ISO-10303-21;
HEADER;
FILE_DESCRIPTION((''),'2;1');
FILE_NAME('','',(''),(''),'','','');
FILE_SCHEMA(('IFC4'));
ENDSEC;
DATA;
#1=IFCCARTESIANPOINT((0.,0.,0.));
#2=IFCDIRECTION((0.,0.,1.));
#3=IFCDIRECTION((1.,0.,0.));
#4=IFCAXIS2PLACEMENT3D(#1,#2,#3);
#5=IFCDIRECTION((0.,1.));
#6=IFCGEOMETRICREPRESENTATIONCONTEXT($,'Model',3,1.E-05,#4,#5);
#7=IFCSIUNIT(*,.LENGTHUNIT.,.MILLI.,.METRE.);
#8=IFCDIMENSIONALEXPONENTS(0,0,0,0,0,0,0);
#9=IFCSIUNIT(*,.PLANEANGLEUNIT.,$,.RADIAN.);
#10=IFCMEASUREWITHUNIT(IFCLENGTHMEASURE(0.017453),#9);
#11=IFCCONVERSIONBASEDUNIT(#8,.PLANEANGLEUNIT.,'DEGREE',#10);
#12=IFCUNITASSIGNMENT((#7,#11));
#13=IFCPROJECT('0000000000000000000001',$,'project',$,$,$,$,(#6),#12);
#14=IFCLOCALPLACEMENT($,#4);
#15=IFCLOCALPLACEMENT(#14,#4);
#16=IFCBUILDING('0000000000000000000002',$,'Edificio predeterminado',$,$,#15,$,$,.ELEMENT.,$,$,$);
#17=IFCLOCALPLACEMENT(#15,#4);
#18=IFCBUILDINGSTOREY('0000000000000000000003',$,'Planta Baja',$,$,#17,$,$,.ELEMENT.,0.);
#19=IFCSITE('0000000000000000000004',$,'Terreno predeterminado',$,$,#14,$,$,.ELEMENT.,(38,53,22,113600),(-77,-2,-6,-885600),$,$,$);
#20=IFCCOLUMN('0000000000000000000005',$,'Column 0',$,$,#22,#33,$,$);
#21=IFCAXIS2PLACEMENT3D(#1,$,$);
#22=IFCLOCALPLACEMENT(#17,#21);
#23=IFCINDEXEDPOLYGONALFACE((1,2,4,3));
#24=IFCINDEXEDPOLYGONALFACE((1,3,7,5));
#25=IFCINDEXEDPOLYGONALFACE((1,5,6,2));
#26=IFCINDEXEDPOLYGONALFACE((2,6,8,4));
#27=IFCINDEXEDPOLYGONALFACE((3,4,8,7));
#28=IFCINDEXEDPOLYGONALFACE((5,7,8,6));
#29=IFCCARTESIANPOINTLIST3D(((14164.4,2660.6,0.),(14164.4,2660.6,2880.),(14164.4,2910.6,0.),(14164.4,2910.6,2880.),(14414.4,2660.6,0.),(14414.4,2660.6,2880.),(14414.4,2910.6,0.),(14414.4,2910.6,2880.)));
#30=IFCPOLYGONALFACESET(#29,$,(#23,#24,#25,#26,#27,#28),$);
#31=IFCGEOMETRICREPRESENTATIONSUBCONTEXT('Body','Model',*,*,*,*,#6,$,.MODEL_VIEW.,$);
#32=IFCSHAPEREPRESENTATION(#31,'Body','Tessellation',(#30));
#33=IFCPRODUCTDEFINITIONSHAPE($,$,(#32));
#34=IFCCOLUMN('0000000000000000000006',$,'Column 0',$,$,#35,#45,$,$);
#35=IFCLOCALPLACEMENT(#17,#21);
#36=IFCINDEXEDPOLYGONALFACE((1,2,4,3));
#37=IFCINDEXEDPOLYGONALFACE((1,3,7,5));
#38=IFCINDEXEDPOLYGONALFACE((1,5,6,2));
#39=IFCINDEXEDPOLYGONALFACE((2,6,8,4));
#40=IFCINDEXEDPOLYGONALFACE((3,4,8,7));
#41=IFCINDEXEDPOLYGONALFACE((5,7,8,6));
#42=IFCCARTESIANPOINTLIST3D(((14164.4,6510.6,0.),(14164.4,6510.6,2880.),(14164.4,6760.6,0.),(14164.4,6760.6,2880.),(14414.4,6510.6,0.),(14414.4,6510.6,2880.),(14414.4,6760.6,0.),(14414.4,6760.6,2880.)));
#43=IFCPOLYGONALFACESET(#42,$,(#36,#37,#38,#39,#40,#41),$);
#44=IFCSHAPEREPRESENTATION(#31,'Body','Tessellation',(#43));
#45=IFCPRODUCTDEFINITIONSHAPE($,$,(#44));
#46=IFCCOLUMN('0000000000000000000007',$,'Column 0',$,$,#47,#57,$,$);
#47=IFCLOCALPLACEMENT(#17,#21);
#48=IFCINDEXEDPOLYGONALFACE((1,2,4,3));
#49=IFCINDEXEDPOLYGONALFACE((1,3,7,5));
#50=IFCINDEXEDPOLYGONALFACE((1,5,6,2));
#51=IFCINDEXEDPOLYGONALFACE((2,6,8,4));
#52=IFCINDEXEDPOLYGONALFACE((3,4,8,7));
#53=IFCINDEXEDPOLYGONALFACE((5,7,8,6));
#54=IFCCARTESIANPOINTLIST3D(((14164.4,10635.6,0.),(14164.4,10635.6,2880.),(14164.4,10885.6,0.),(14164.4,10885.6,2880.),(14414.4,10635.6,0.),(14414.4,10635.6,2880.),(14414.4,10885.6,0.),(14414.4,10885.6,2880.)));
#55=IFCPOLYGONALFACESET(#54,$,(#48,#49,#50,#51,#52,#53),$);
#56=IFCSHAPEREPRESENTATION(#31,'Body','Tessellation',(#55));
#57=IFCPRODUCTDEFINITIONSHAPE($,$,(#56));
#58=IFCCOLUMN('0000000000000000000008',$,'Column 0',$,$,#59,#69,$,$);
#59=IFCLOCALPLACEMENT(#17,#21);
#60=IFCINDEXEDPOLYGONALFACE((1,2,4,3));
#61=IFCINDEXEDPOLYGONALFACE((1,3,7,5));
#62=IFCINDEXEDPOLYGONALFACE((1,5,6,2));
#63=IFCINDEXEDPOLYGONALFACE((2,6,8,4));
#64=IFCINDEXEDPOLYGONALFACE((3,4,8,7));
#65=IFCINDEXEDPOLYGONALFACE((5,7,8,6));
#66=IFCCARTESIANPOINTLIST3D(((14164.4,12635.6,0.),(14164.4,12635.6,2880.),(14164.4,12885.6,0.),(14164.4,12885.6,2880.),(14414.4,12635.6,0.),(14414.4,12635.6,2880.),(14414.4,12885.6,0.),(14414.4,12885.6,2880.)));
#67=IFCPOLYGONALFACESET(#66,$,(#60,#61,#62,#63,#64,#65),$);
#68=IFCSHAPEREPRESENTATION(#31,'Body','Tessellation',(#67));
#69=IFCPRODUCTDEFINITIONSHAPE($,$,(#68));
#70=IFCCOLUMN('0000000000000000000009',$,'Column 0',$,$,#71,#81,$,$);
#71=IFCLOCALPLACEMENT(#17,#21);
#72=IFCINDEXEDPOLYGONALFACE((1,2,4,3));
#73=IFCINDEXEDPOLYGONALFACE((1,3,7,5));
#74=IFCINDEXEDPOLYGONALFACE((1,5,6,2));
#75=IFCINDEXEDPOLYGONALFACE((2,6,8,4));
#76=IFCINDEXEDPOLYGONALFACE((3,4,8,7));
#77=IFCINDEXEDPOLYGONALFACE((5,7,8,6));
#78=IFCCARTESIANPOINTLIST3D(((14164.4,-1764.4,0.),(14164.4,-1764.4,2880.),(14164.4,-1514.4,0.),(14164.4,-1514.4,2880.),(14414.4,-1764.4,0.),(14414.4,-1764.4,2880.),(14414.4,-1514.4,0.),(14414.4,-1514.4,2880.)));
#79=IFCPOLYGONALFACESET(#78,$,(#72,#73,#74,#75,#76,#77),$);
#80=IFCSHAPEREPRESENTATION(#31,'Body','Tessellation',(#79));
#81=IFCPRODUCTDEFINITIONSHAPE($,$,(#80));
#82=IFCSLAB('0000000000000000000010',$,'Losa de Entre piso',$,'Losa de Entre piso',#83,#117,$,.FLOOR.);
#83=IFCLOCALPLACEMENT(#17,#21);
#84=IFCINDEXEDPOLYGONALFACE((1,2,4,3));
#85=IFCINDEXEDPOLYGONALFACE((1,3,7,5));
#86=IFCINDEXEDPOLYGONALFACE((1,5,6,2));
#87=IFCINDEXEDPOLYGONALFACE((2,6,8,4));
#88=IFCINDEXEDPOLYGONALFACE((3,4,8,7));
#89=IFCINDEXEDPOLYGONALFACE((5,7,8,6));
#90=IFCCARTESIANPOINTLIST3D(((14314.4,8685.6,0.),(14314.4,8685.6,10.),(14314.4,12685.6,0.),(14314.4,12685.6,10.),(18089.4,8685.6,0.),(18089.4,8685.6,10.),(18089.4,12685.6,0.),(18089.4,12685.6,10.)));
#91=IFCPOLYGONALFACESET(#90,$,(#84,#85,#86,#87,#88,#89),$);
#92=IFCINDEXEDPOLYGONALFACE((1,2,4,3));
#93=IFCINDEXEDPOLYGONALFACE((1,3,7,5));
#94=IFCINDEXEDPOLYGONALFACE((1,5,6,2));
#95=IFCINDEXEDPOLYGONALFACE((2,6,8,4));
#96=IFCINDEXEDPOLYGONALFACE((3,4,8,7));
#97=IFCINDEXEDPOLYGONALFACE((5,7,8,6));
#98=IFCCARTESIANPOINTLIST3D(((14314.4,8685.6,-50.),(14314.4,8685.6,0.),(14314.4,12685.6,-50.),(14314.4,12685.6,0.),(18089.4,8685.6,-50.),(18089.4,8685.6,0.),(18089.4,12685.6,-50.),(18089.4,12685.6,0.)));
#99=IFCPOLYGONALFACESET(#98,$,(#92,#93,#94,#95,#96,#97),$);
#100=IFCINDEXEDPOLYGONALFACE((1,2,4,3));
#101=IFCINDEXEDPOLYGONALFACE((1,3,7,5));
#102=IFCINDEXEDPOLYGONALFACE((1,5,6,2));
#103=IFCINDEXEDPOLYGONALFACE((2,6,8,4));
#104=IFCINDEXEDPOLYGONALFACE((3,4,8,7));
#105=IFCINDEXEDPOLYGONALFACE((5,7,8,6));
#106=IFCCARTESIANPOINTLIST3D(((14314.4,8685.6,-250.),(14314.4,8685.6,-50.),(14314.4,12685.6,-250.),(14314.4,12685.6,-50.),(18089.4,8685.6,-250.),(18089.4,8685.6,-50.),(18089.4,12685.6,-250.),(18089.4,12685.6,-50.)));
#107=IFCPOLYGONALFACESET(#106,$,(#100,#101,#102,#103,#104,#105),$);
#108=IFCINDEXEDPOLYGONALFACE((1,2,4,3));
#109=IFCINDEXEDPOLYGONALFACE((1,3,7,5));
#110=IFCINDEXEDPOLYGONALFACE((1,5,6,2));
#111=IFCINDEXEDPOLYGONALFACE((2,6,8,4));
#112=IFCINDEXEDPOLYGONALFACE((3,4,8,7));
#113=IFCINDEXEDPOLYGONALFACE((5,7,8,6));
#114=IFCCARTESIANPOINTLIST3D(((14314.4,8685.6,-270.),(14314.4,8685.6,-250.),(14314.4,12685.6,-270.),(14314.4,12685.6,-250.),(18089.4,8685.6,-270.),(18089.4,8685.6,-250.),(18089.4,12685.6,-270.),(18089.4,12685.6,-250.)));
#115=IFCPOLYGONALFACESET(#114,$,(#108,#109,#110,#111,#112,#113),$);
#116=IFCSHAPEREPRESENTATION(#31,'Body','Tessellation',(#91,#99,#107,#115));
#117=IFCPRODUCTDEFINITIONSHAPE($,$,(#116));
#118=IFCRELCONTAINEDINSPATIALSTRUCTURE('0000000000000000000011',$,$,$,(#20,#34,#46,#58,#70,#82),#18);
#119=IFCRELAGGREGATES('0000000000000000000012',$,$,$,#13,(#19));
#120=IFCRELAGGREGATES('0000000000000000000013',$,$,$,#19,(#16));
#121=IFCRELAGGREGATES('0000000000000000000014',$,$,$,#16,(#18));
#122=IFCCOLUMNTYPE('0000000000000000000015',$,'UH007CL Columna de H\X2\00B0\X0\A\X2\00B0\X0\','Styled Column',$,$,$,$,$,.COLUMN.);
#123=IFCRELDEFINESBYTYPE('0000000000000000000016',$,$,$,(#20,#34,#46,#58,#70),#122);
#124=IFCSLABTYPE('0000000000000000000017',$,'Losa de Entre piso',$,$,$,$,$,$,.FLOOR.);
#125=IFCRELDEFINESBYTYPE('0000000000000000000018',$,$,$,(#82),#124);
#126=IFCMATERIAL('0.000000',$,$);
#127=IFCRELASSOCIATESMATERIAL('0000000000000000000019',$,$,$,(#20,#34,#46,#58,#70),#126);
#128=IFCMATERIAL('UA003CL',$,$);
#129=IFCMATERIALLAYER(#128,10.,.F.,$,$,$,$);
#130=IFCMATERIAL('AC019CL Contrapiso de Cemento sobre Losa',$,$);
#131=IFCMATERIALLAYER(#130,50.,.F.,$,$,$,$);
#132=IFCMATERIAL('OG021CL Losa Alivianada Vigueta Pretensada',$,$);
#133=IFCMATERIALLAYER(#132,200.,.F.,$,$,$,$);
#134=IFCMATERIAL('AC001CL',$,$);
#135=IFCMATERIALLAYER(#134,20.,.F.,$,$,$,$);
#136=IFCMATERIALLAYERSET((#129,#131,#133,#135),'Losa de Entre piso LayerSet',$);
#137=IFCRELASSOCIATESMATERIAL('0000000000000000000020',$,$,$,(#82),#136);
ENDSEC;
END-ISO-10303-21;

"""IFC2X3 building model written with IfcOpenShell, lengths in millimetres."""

from ifc_helpers import new_model, entity, si_unit, converted_unit, direction, frame, origin_with_axes, place, context, subcontext, project, spatial, polyline, outline, extrude, material, layer, layer_set, layer_usage, type_object, element, save


model = new_model("IFC2X3")

# Units and contexts
model_context = context("Model", 3, precision=1e-05, world=origin_with_axes(), true_north=direction((0.0, 1.0)))
body_context = subcontext(model_context, "Body", "Model", "MODEL_VIEW")
ifc_project = project(units=[si_unit("LENGTHUNIT", "METRE", prefix="MILLI"), converted_unit("PLANEANGLEUNIT", "DEGREE", entity("IfcLengthMeasure", 0.017453), si_unit("PLANEANGLEUNIT", "RADIAN"), dimensions=[0, 0, 0, 0, 0, 0, 0])], contexts=[model_context])

# Site, building, storey
site_placement = place(None, origin_with_axes())
site = spatial("IfcSite", under=ifc_project, at=site_placement, Name="Terreno predeterminado", CompositionType="ELEMENT", RefLatitude=(38, 53, 22, 113600), RefLongitude=(-77, -2, -6, -885600))
building_placement = place(site_placement, origin_with_axes())
building = spatial("IfcBuilding", under=site, at=building_placement, Name="Edificio predeterminado", CompositionType="ELEMENT")
storey_placement = place(building_placement, origin_with_axes())
storey = spatial("IfcBuildingStorey", under=building, at=storey_placement, Name="Planta Baja", CompositionType="ELEMENT", Elevation=0.0)

# Columns
ifc_material_1 = material(Name="0.000000")
column_type = type_object("IfcColumnType", Name="UH007CL Columna de H°A°", Description="Styled Column", PredefinedType="COLUMN")
for number, where, z_axis, x_axis, name in (
    (1, (14289.4, 2785.6, 0.0), (0.0, 0.0, 1.0), (1.0, 0.0, 0.0), "Column 0"),
    (2, (14289.4, 6635.6, 0.0), (0.0, 0.0, 1.0), (1.0, 0.0, 0.0), "Column 0"),
    (3, (14289.4, 10760.6, 0.0), (0.0, 0.0, 1.0), (1.0, 0.0, 0.0), "Column 0"),
    (4, (14289.4, 12760.6, 0.0), (0.0, 0.0, 1.0), (1.0, 0.0, 0.0), "Column 0"),
    (5, (14289.4, -1639.4, 0.0), (0.0, 0.0, 1.0), (1.0, 0.0, 0.0), "Column 0"),
):
    element("IfcColumn", number, at=place(storey_placement, frame(where, z_axis=z_axis, x_axis=x_axis)), inside=storey, type_object=column_type, material=ifc_material_1, Name=name, context=body_context, shape_type="SweptSolid", body=[
        extrude(outline(polyline([(-125.0, -125.0), (125.0, -125.0), (125.0, 125.0), (-125.0, 125.0), (-125.0, -125.0)])), origin_with_axes(), (0.0, 0.0, 1.0), 2880.0),
    ])

# Slab
ifc_material_2 = material(Name="UA003CL")
ifc_layer_1 = layer(ifc_material_2, 10.0, ventilated=False)
ifc_material_3 = material(Name="AC019CL Contrapiso de Cemento sobre Losa")
ifc_layer_2 = layer(ifc_material_3, 50.0, ventilated=False)
ifc_material_4 = material(Name="OG021CL Losa Alivianada Vigueta Pretensada")
ifc_layer_3 = layer(ifc_material_4, 200.0, ventilated=False)
ifc_material_5 = material(Name="AC001CL")
ifc_layer_4 = layer(ifc_material_5, 20.0, ventilated=False)
ifc_layer_set_1 = layer_set([ifc_layer_1, ifc_layer_2, ifc_layer_3, ifc_layer_4], Name="Losa de Entre piso LayerSet")
ifc_layer_usage_1 = layer_usage(ifc_layer_set_1, "AXIS3", "NEGATIVE", 0.0)
slab_type = type_object("IfcSlabType", Name="Losa de Entre piso", PredefinedType="FLOOR")
slab_1_placement = place(storey_placement, origin_with_axes())
element("IfcSlab", 6, at=slab_1_placement, inside=storey, type_object=slab_type, material=ifc_layer_usage_1, Name="Losa de Entre piso", ObjectType="Losa de Entre piso", PredefinedType="FLOOR", context=body_context, shape_type="SweptSolid", body=[
    extrude(outline(polyline([(0.0, 4000.0), (3775.0, 4000.0), (3775.0, 0.0), (0.0, 0.0), (0.0, 4000.0)])), frame((14314.4, 12685.6, 0.0), z_axis=(0.0, 0.0, -1.0), x_axis=(1.0, 0.0, 0.0)), (0.0, 0.0, -1.0), 10.0),
    extrude(outline(polyline([(0.0, 4000.0), (3775.0, 4000.0), (3775.0, 0.0), (0.0, 0.0), (0.0, 4000.0)])), frame((14314.4, 12685.6, -50.0), z_axis=(0.0, 0.0, -1.0), x_axis=(1.0, 0.0, 0.0)), (0.0, 0.0, -1.0), 50.0),
    extrude(outline(polyline([(0.0, 4000.0), (3775.0, 4000.0), (3775.0, 0.0), (0.0, 0.0), (0.0, 4000.0)])), frame((14314.4, 12685.6, -250.0), z_axis=(0.0, 0.0, -1.0), x_axis=(1.0, 0.0, 0.0)), (0.0, 0.0, -1.0), 200.0),
    extrude(outline(polyline([(0.0, 4000.0), (3775.0, 4000.0), (3775.0, 0.0), (0.0, 0.0), (0.0, 4000.0)])), frame((14314.4, 12685.6, -270.0), z_axis=(0.0, 0.0, -1.0), x_axis=(1.0, 0.0, 0.0)), (0.0, 0.0, -1.0), 20.0),
])

save(model, "model.ifc")
